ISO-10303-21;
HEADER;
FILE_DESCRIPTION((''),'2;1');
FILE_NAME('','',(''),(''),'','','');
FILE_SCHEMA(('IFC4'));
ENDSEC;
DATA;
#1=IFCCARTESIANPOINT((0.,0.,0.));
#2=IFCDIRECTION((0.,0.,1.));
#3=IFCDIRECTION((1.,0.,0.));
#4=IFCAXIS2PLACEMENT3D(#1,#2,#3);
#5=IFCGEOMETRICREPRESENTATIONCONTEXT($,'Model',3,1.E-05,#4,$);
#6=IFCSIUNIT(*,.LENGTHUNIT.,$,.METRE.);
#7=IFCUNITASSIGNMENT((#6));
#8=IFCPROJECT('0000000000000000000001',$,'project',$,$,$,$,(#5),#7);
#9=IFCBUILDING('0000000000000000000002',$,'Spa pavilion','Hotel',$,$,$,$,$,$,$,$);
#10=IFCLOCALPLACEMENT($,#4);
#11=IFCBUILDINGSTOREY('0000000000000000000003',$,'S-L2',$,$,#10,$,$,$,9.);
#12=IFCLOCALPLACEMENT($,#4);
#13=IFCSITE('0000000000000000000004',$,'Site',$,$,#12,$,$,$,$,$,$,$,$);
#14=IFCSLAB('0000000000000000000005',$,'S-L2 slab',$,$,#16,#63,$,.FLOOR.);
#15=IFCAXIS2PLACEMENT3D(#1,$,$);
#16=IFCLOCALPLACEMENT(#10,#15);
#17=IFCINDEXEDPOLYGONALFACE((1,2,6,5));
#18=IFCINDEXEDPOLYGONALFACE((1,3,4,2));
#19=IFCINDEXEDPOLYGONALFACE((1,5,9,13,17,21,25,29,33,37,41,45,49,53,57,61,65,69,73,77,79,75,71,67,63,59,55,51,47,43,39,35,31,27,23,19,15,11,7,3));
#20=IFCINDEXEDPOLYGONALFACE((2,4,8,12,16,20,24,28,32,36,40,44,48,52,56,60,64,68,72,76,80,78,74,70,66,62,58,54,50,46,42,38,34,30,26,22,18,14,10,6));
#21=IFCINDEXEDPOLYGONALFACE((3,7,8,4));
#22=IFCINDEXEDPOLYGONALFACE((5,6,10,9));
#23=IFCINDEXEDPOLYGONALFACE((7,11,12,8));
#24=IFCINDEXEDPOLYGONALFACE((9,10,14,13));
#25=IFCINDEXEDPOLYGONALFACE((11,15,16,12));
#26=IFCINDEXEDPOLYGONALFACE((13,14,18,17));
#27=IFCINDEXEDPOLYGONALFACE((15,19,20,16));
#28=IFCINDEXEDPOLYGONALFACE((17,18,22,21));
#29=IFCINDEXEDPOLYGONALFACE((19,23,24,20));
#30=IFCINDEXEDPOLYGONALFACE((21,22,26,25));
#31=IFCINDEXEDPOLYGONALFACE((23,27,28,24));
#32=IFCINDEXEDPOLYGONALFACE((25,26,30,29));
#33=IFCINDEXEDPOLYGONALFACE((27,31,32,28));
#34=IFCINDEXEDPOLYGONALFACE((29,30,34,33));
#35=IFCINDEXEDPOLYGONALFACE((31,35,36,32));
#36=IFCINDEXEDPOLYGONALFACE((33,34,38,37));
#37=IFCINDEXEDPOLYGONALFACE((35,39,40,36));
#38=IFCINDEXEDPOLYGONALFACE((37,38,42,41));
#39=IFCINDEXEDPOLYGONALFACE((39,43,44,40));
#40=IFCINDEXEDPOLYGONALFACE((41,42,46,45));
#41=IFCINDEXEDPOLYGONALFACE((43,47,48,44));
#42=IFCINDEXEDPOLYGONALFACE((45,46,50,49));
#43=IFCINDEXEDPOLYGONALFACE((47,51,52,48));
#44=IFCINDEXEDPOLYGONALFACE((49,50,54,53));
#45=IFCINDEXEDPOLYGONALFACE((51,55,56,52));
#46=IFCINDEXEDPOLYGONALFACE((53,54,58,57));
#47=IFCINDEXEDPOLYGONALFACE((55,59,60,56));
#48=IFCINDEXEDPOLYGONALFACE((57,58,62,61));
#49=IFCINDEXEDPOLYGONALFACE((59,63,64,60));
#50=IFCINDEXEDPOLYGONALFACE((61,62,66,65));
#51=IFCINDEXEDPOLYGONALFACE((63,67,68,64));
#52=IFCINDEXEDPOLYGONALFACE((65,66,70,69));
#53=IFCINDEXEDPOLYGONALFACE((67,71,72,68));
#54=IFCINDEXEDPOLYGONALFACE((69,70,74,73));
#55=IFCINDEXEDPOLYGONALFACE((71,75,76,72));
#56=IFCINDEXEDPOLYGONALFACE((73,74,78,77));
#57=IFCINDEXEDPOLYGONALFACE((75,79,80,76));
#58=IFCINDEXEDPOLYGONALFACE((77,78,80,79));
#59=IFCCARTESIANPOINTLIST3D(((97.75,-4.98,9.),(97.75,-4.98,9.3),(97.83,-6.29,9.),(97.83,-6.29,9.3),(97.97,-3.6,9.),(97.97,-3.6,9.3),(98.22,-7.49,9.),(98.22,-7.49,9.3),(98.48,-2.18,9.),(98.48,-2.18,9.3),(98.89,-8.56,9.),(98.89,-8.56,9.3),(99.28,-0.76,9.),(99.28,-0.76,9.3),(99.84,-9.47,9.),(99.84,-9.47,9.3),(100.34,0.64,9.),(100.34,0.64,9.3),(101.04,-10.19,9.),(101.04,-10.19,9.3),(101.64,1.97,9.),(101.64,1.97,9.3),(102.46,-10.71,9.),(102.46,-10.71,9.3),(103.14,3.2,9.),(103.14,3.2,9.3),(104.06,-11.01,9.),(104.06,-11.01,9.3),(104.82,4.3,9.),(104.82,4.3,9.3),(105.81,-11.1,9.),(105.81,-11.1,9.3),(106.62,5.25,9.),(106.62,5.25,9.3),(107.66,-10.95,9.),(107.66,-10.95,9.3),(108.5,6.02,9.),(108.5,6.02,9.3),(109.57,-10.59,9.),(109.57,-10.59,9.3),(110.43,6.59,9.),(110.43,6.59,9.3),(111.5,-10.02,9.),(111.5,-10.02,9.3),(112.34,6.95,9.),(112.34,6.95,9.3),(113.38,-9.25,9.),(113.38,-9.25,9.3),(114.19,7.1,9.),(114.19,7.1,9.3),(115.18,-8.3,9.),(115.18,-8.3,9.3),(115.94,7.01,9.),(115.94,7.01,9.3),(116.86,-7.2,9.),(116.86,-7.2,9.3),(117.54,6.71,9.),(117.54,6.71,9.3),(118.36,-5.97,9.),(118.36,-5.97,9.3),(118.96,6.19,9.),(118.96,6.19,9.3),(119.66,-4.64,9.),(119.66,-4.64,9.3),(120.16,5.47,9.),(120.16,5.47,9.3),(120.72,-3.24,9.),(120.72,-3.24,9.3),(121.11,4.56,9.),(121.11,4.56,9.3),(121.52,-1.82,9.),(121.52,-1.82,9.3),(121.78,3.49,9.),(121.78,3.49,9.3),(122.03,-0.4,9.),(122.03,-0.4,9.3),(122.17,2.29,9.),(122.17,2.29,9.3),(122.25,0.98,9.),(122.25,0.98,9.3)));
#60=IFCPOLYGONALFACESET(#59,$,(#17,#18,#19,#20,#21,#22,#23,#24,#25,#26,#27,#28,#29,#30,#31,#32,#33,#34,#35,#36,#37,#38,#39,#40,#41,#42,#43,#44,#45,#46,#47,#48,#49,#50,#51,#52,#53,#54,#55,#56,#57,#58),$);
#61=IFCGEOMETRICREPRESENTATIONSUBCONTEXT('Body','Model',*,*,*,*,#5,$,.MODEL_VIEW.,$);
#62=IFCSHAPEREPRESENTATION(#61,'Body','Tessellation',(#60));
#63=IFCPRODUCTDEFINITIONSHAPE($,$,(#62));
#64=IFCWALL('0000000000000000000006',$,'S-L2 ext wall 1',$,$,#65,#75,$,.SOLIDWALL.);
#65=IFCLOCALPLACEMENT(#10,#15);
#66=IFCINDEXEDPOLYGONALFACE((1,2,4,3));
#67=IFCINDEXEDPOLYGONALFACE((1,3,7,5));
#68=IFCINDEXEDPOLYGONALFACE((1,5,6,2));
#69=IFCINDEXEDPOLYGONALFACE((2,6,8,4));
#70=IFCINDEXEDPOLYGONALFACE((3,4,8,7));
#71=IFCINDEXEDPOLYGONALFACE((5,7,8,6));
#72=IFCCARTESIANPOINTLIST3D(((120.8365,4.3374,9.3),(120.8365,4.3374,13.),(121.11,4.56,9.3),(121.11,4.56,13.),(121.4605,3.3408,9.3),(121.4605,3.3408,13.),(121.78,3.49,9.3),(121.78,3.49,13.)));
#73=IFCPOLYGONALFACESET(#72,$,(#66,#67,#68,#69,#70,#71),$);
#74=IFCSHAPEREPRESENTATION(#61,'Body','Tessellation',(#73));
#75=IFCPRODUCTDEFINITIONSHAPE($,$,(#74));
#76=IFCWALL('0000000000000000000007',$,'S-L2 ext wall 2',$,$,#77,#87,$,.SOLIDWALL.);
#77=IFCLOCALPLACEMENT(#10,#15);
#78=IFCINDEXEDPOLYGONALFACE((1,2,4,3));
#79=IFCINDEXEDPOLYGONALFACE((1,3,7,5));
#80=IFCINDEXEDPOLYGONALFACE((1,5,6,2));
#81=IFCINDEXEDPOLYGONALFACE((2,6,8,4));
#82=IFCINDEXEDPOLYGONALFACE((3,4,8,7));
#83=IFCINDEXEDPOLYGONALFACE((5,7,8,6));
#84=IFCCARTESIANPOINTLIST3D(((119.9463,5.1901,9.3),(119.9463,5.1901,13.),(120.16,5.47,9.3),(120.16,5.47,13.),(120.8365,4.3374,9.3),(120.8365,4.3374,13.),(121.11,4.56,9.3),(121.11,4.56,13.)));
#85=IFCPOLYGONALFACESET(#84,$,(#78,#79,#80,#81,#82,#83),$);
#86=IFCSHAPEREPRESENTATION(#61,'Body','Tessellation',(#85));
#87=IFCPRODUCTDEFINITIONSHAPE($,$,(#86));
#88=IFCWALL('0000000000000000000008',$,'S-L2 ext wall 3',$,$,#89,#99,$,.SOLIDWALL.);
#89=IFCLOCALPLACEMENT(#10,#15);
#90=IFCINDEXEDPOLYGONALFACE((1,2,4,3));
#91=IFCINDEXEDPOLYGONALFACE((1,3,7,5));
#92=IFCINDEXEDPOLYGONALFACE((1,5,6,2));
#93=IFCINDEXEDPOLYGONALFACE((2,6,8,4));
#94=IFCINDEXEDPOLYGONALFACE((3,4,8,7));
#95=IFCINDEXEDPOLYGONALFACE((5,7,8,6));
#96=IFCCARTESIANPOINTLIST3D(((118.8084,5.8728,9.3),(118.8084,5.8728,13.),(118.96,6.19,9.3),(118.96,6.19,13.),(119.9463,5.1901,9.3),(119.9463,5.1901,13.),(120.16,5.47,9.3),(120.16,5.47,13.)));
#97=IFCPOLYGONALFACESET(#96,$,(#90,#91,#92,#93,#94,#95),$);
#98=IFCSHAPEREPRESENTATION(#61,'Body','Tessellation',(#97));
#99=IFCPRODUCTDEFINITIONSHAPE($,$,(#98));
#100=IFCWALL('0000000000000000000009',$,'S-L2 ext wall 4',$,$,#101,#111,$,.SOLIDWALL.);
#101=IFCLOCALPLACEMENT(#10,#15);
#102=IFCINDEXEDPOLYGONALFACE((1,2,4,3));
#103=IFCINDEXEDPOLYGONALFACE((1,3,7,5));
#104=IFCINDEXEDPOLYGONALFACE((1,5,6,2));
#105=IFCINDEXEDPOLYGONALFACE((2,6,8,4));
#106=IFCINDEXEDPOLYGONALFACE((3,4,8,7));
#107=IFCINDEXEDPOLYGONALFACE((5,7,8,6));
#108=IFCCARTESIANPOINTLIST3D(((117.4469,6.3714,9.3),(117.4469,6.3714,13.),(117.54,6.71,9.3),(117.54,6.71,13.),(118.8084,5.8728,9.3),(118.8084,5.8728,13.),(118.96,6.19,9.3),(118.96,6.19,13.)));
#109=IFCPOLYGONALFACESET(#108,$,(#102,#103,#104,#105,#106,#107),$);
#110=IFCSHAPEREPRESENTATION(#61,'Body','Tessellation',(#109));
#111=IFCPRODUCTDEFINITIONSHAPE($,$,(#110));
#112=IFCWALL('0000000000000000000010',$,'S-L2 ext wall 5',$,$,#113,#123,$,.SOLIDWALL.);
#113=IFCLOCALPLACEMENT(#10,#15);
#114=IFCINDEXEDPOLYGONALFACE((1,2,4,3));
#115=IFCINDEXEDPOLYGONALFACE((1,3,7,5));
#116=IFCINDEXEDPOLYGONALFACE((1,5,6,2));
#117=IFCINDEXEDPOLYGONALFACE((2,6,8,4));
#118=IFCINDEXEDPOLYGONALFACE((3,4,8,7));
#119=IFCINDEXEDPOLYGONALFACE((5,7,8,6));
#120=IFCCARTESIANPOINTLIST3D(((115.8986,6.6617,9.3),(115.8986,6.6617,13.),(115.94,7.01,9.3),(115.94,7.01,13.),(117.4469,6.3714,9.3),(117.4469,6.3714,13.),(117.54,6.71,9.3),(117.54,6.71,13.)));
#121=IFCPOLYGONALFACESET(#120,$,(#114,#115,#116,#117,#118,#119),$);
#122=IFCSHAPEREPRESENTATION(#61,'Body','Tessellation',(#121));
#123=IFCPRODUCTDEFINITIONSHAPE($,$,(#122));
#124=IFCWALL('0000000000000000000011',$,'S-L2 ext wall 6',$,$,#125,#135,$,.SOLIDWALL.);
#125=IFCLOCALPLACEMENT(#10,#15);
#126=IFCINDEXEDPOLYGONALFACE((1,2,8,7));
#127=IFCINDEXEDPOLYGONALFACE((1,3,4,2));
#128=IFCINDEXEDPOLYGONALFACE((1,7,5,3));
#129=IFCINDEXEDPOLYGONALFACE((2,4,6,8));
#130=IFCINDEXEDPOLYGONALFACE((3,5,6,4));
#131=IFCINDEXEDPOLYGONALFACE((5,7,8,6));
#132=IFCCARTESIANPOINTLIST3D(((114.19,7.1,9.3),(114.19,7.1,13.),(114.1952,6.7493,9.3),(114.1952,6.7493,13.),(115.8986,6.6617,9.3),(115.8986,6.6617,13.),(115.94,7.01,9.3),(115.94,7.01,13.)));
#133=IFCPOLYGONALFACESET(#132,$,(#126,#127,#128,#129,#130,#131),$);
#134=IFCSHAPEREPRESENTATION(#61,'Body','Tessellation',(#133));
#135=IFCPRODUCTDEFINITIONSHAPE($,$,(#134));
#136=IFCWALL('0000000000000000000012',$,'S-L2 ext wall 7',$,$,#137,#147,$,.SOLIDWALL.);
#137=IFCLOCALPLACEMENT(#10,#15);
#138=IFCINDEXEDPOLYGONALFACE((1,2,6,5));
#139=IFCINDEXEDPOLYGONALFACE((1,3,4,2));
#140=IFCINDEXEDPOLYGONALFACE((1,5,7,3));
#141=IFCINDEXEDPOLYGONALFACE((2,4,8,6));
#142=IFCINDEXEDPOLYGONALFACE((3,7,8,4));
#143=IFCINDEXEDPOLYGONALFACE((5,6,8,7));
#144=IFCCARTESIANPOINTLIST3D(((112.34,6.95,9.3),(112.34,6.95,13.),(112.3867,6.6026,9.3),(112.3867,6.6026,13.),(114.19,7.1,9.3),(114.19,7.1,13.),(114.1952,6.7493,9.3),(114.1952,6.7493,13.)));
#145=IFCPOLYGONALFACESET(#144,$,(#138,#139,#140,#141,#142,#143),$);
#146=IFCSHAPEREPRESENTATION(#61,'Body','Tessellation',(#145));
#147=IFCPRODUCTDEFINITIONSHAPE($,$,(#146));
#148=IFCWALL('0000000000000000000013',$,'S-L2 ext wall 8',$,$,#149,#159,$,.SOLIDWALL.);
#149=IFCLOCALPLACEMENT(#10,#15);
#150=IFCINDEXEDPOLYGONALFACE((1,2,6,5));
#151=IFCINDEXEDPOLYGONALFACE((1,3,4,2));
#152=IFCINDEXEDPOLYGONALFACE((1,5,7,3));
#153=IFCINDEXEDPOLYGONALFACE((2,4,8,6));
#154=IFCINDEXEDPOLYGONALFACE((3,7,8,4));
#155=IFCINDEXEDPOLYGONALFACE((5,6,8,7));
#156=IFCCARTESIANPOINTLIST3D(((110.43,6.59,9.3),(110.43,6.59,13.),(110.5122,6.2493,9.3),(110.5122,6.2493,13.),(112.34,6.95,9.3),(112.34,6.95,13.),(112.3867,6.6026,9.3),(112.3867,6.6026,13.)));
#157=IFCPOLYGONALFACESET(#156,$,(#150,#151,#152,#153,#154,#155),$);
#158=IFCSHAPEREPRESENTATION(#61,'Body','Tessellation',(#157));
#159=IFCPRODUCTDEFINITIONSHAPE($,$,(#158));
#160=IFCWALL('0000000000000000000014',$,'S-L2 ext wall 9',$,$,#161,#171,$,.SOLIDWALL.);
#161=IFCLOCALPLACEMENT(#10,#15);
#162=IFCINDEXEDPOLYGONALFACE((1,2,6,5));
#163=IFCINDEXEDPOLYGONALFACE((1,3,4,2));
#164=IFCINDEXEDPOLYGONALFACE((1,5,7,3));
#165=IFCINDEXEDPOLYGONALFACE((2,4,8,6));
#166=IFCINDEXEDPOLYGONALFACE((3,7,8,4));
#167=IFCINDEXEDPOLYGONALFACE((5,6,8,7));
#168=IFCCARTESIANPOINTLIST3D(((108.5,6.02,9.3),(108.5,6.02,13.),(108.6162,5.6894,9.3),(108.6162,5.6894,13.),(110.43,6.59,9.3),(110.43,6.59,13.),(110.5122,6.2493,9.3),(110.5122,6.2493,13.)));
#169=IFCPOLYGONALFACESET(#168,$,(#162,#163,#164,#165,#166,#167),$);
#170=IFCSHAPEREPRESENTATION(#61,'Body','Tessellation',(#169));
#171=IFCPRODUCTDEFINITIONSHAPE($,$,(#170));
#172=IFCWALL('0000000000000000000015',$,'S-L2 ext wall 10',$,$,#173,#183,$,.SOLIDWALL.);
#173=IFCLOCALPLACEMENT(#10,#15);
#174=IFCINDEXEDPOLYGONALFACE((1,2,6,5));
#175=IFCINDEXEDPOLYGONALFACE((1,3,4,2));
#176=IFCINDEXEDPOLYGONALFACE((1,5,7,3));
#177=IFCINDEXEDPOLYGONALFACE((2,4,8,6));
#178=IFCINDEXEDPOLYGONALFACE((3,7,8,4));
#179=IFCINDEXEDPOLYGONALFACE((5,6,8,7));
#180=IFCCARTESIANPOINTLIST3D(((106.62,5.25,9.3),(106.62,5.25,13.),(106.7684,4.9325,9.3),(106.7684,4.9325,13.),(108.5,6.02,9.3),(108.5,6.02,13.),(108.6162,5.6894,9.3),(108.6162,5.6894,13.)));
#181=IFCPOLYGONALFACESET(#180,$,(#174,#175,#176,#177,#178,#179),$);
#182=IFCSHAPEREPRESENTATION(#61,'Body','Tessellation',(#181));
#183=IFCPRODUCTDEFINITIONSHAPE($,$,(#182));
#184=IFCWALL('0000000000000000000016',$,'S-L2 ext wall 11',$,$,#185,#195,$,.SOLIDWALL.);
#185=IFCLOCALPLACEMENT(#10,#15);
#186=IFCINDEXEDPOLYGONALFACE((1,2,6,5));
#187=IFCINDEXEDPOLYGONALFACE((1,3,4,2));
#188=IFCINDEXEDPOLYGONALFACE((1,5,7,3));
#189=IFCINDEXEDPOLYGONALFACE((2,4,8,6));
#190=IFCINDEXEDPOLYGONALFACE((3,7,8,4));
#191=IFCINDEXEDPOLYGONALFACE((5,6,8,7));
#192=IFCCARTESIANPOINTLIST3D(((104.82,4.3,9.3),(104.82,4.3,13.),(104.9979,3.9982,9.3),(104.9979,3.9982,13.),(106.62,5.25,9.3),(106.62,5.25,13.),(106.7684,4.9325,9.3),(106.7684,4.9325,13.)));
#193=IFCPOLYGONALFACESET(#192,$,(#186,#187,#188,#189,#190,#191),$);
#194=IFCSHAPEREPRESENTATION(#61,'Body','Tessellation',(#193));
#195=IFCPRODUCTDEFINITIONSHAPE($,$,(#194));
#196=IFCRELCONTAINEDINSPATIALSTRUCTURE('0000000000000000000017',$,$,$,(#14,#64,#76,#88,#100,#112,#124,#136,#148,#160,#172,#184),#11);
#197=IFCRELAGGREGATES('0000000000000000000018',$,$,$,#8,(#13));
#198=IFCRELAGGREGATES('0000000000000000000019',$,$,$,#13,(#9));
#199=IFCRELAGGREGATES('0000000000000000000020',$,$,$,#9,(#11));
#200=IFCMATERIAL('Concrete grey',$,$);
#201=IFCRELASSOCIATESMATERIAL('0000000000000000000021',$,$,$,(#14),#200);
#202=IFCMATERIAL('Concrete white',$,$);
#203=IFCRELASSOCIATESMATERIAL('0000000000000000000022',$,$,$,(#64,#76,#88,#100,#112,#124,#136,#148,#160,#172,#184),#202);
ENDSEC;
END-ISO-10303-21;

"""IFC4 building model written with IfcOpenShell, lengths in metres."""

from ifc_helpers import new_model, si_unit, frame, origin_with_axes, place, context, subcontext, project, spatial, polyline, outline, extrude, material, element, save


model = new_model("IFC4")

# Units and contexts
model_context = context("Model", 3, precision=1e-05, world=origin_with_axes())
body_context = subcontext(model_context, "Body", "Model", "MODEL_VIEW")
ifc_project = project(units=[si_unit("LENGTHUNIT", "METRE")], contexts=[model_context])

# Site, building, storey
site_placement = place(None, origin_with_axes())
site = spatial("IfcSite", under=ifc_project, at=site_placement, Name="Site")
building = spatial("IfcBuilding", under=site, Name="Spa pavilion", Description="Hotel")
storey_placement = place(None, origin_with_axes())
storey = spatial("IfcBuildingStorey", under=building, at=storey_placement, Name="S-L2", Elevation=9.0)

# Slab
ifc_material_1 = material(Name="Concrete grey")
slab_placement = place(storey_placement, origin_with_axes())
element("IfcSlab", 1, at=slab_placement, inside=storey, material=ifc_material_1, Name="S-L2 slab", PredefinedType="FLOOR", context=body_context, shape_type="SweptSolid", body=[
    extrude(outline(polyline([(121.78, 3.49), (121.11, 4.56), (120.16, 5.47), (118.96, 6.19), (117.54, 6.71), (115.94, 7.01), (114.19, 7.1), (112.34, 6.95), (110.43, 6.59), (108.5, 6.02), (106.62, 5.25), (104.82, 4.3), (103.14, 3.2), (101.64, 1.97), (100.34, 0.64), (99.28, -0.76), (98.48, -2.18), (97.97, -3.6), (97.75, -4.98), (97.83, -6.29), (98.22, -7.49), (98.89, -8.56), (99.84, -9.47), (101.04, -10.19), (102.46, -10.71), (104.06, -11.01), (105.81, -11.1), (107.66, -10.95), (109.57, -10.59), (111.5, -10.02), (113.38, -9.25), (115.18, -8.3), (116.86, -7.2), (118.36, -5.97), (119.66, -4.64), (120.72, -3.24), (121.52, -1.82), (122.03, -0.4), (122.25, 0.98), (122.17, 2.29), (121.78, 3.49)])), frame((0.0, 0.0, 9.0), z_axis=(0.0, 0.0, 1.0), x_axis=(1.0, 0.0, 0.0)), (0.0, 0.0, 1.0), 0.3),
])

# Walls
ifc_material_2 = material(Name="Concrete white")
wall_1_placement = place(storey_placement, origin_with_axes())
element("IfcWall", 2, at=wall_1_placement, inside=storey, material=ifc_material_2, Name="S-L2 ext wall 1", PredefinedType="SOLIDWALL", context=body_context, shape_type="SweptSolid", body=[
    extrude(outline(polyline([(121.78, 3.49), (121.11, 4.56), (120.8365, 4.3374), (121.4605, 3.3408), (121.78, 3.49)])), frame((0.0, 0.0, 9.3), z_axis=(0.0, 0.0, 1.0), x_axis=(1.0, 0.0, 0.0)), (0.0, 0.0, 1.0), 3.7),
])
wall_2_placement = place(storey_placement, origin_with_axes())
element("IfcWall", 3, at=wall_2_placement, inside=storey, material=ifc_material_2, Name="S-L2 ext wall 2", PredefinedType="SOLIDWALL", context=body_context, shape_type="SweptSolid", body=[
    extrude(outline(polyline([(121.11, 4.56), (120.16, 5.47), (119.9463, 5.1901), (120.8365, 4.3374), (121.11, 4.56)])), frame((0.0, 0.0, 9.3), z_axis=(0.0, 0.0, 1.0), x_axis=(1.0, 0.0, 0.0)), (0.0, 0.0, 1.0), 3.7),
])
wall_3_placement = place(storey_placement, origin_with_axes())
element("IfcWall", 4, at=wall_3_placement, inside=storey, material=ifc_material_2, Name="S-L2 ext wall 3", PredefinedType="SOLIDWALL", context=body_context, shape_type="SweptSolid", body=[
    extrude(outline(polyline([(120.16, 5.47), (118.96, 6.19), (118.8084, 5.8728), (119.9463, 5.1901), (120.16, 5.47)])), frame((0.0, 0.0, 9.3), z_axis=(0.0, 0.0, 1.0), x_axis=(1.0, 0.0, 0.0)), (0.0, 0.0, 1.0), 3.7),
])
wall_4_placement = place(storey_placement, origin_with_axes())
element("IfcWall", 5, at=wall_4_placement, inside=storey, material=ifc_material_2, Name="S-L2 ext wall 4", PredefinedType="SOLIDWALL", context=body_context, shape_type="SweptSolid", body=[
    extrude(outline(polyline([(118.96, 6.19), (117.54, 6.71), (117.4469, 6.3714), (118.8084, 5.8728), (118.96, 6.19)])), frame((0.0, 0.0, 9.3), z_axis=(0.0, 0.0, 1.0), x_axis=(1.0, 0.0, 0.0)), (0.0, 0.0, 1.0), 3.7),
])
wall_5_placement = place(storey_placement, origin_with_axes())
element("IfcWall", 6, at=wall_5_placement, inside=storey, material=ifc_material_2, Name="S-L2 ext wall 5", PredefinedType="SOLIDWALL", context=body_context, shape_type="SweptSolid", body=[
    extrude(outline(polyline([(117.54, 6.71), (115.94, 7.01), (115.8986, 6.6617), (117.4469, 6.3714), (117.54, 6.71)])), frame((0.0, 0.0, 9.3), z_axis=(0.0, 0.0, 1.0), x_axis=(1.0, 0.0, 0.0)), (0.0, 0.0, 1.0), 3.7),
])
wall_6_placement = place(storey_placement, origin_with_axes())
element("IfcWall", 7, at=wall_6_placement, inside=storey, material=ifc_material_2, Name="S-L2 ext wall 6", PredefinedType="SOLIDWALL", context=body_context, shape_type="SweptSolid", body=[
    extrude(outline(polyline([(115.94, 7.01), (114.19, 7.1), (114.1952, 6.7493), (115.8986, 6.6617), (115.94, 7.01)])), frame((0.0, 0.0, 9.3), z_axis=(0.0, 0.0, 1.0), x_axis=(1.0, 0.0, 0.0)), (0.0, 0.0, 1.0), 3.7),
])
wall_7_placement = place(storey_placement, origin_with_axes())
element("IfcWall", 8, at=wall_7_placement, inside=storey, material=ifc_material_2, Name="S-L2 ext wall 7", PredefinedType="SOLIDWALL", context=body_context, shape_type="SweptSolid", body=[
    extrude(outline(polyline([(114.19, 7.1), (112.34, 6.95), (112.3867, 6.6026), (114.1952, 6.7493), (114.19, 7.1)])), frame((0.0, 0.0, 9.3), z_axis=(0.0, 0.0, 1.0), x_axis=(1.0, 0.0, 0.0)), (0.0, 0.0, 1.0), 3.7),
])
wall_8_placement = place(storey_placement, origin_with_axes())
element("IfcWall", 9, at=wall_8_placement, inside=storey, material=ifc_material_2, Name="S-L2 ext wall 8", PredefinedType="SOLIDWALL", context=body_context, shape_type="SweptSolid", body=[
    extrude(outline(polyline([(112.34, 6.95), (110.43, 6.59), (110.5122, 6.2493), (112.3867, 6.6026), (112.34, 6.95)])), frame((0.0, 0.0, 9.3), z_axis=(0.0, 0.0, 1.0), x_axis=(1.0, 0.0, 0.0)), (0.0, 0.0, 1.0), 3.7),
])
wall_9_placement = place(storey_placement, origin_with_axes())
element("IfcWall", 10, at=wall_9_placement, inside=storey, material=ifc_material_2, Name="S-L2 ext wall 9", PredefinedType="SOLIDWALL", context=body_context, shape_type="SweptSolid", body=[
    extrude(outline(polyline([(110.43, 6.59), (108.5, 6.02), (108.6162, 5.6894), (110.5122, 6.2493), (110.43, 6.59)])), frame((0.0, 0.0, 9.3), z_axis=(0.0, 0.0, 1.0), x_axis=(1.0, 0.0, 0.0)), (0.0, 0.0, 1.0), 3.7),
])
wall_10_placement = place(storey_placement, origin_with_axes())
element("IfcWall", 11, at=wall_10_placement, inside=storey, material=ifc_material_2, Name="S-L2 ext wall 10", PredefinedType="SOLIDWALL", context=body_context, shape_type="SweptSolid", body=[
    extrude(outline(polyline([(108.5, 6.02), (106.62, 5.25), (106.7684, 4.9325), (108.6162, 5.6894), (108.5, 6.02)])), frame((0.0, 0.0, 9.3), z_axis=(0.0, 0.0, 1.0), x_axis=(1.0, 0.0, 0.0)), (0.0, 0.0, 1.0), 3.7),
])
wall_11_placement = place(storey_placement, origin_with_axes())
element("IfcWall", 12, at=wall_11_placement, inside=storey, material=ifc_material_2, Name="S-L2 ext wall 11", PredefinedType="SOLIDWALL", context=body_context, shape_type="SweptSolid", body=[
    extrude(outline(polyline([(106.62, 5.25), (104.82, 4.3), (104.9979, 3.9982), (106.7684, 4.9325), (106.62, 5.25)])), frame((0.0, 0.0, 9.3), z_axis=(0.0, 0.0, 1.0), x_axis=(1.0, 0.0, 0.0)), (0.0, 0.0, 1.0), 3.7),
])

save(model, "model.ifc")
